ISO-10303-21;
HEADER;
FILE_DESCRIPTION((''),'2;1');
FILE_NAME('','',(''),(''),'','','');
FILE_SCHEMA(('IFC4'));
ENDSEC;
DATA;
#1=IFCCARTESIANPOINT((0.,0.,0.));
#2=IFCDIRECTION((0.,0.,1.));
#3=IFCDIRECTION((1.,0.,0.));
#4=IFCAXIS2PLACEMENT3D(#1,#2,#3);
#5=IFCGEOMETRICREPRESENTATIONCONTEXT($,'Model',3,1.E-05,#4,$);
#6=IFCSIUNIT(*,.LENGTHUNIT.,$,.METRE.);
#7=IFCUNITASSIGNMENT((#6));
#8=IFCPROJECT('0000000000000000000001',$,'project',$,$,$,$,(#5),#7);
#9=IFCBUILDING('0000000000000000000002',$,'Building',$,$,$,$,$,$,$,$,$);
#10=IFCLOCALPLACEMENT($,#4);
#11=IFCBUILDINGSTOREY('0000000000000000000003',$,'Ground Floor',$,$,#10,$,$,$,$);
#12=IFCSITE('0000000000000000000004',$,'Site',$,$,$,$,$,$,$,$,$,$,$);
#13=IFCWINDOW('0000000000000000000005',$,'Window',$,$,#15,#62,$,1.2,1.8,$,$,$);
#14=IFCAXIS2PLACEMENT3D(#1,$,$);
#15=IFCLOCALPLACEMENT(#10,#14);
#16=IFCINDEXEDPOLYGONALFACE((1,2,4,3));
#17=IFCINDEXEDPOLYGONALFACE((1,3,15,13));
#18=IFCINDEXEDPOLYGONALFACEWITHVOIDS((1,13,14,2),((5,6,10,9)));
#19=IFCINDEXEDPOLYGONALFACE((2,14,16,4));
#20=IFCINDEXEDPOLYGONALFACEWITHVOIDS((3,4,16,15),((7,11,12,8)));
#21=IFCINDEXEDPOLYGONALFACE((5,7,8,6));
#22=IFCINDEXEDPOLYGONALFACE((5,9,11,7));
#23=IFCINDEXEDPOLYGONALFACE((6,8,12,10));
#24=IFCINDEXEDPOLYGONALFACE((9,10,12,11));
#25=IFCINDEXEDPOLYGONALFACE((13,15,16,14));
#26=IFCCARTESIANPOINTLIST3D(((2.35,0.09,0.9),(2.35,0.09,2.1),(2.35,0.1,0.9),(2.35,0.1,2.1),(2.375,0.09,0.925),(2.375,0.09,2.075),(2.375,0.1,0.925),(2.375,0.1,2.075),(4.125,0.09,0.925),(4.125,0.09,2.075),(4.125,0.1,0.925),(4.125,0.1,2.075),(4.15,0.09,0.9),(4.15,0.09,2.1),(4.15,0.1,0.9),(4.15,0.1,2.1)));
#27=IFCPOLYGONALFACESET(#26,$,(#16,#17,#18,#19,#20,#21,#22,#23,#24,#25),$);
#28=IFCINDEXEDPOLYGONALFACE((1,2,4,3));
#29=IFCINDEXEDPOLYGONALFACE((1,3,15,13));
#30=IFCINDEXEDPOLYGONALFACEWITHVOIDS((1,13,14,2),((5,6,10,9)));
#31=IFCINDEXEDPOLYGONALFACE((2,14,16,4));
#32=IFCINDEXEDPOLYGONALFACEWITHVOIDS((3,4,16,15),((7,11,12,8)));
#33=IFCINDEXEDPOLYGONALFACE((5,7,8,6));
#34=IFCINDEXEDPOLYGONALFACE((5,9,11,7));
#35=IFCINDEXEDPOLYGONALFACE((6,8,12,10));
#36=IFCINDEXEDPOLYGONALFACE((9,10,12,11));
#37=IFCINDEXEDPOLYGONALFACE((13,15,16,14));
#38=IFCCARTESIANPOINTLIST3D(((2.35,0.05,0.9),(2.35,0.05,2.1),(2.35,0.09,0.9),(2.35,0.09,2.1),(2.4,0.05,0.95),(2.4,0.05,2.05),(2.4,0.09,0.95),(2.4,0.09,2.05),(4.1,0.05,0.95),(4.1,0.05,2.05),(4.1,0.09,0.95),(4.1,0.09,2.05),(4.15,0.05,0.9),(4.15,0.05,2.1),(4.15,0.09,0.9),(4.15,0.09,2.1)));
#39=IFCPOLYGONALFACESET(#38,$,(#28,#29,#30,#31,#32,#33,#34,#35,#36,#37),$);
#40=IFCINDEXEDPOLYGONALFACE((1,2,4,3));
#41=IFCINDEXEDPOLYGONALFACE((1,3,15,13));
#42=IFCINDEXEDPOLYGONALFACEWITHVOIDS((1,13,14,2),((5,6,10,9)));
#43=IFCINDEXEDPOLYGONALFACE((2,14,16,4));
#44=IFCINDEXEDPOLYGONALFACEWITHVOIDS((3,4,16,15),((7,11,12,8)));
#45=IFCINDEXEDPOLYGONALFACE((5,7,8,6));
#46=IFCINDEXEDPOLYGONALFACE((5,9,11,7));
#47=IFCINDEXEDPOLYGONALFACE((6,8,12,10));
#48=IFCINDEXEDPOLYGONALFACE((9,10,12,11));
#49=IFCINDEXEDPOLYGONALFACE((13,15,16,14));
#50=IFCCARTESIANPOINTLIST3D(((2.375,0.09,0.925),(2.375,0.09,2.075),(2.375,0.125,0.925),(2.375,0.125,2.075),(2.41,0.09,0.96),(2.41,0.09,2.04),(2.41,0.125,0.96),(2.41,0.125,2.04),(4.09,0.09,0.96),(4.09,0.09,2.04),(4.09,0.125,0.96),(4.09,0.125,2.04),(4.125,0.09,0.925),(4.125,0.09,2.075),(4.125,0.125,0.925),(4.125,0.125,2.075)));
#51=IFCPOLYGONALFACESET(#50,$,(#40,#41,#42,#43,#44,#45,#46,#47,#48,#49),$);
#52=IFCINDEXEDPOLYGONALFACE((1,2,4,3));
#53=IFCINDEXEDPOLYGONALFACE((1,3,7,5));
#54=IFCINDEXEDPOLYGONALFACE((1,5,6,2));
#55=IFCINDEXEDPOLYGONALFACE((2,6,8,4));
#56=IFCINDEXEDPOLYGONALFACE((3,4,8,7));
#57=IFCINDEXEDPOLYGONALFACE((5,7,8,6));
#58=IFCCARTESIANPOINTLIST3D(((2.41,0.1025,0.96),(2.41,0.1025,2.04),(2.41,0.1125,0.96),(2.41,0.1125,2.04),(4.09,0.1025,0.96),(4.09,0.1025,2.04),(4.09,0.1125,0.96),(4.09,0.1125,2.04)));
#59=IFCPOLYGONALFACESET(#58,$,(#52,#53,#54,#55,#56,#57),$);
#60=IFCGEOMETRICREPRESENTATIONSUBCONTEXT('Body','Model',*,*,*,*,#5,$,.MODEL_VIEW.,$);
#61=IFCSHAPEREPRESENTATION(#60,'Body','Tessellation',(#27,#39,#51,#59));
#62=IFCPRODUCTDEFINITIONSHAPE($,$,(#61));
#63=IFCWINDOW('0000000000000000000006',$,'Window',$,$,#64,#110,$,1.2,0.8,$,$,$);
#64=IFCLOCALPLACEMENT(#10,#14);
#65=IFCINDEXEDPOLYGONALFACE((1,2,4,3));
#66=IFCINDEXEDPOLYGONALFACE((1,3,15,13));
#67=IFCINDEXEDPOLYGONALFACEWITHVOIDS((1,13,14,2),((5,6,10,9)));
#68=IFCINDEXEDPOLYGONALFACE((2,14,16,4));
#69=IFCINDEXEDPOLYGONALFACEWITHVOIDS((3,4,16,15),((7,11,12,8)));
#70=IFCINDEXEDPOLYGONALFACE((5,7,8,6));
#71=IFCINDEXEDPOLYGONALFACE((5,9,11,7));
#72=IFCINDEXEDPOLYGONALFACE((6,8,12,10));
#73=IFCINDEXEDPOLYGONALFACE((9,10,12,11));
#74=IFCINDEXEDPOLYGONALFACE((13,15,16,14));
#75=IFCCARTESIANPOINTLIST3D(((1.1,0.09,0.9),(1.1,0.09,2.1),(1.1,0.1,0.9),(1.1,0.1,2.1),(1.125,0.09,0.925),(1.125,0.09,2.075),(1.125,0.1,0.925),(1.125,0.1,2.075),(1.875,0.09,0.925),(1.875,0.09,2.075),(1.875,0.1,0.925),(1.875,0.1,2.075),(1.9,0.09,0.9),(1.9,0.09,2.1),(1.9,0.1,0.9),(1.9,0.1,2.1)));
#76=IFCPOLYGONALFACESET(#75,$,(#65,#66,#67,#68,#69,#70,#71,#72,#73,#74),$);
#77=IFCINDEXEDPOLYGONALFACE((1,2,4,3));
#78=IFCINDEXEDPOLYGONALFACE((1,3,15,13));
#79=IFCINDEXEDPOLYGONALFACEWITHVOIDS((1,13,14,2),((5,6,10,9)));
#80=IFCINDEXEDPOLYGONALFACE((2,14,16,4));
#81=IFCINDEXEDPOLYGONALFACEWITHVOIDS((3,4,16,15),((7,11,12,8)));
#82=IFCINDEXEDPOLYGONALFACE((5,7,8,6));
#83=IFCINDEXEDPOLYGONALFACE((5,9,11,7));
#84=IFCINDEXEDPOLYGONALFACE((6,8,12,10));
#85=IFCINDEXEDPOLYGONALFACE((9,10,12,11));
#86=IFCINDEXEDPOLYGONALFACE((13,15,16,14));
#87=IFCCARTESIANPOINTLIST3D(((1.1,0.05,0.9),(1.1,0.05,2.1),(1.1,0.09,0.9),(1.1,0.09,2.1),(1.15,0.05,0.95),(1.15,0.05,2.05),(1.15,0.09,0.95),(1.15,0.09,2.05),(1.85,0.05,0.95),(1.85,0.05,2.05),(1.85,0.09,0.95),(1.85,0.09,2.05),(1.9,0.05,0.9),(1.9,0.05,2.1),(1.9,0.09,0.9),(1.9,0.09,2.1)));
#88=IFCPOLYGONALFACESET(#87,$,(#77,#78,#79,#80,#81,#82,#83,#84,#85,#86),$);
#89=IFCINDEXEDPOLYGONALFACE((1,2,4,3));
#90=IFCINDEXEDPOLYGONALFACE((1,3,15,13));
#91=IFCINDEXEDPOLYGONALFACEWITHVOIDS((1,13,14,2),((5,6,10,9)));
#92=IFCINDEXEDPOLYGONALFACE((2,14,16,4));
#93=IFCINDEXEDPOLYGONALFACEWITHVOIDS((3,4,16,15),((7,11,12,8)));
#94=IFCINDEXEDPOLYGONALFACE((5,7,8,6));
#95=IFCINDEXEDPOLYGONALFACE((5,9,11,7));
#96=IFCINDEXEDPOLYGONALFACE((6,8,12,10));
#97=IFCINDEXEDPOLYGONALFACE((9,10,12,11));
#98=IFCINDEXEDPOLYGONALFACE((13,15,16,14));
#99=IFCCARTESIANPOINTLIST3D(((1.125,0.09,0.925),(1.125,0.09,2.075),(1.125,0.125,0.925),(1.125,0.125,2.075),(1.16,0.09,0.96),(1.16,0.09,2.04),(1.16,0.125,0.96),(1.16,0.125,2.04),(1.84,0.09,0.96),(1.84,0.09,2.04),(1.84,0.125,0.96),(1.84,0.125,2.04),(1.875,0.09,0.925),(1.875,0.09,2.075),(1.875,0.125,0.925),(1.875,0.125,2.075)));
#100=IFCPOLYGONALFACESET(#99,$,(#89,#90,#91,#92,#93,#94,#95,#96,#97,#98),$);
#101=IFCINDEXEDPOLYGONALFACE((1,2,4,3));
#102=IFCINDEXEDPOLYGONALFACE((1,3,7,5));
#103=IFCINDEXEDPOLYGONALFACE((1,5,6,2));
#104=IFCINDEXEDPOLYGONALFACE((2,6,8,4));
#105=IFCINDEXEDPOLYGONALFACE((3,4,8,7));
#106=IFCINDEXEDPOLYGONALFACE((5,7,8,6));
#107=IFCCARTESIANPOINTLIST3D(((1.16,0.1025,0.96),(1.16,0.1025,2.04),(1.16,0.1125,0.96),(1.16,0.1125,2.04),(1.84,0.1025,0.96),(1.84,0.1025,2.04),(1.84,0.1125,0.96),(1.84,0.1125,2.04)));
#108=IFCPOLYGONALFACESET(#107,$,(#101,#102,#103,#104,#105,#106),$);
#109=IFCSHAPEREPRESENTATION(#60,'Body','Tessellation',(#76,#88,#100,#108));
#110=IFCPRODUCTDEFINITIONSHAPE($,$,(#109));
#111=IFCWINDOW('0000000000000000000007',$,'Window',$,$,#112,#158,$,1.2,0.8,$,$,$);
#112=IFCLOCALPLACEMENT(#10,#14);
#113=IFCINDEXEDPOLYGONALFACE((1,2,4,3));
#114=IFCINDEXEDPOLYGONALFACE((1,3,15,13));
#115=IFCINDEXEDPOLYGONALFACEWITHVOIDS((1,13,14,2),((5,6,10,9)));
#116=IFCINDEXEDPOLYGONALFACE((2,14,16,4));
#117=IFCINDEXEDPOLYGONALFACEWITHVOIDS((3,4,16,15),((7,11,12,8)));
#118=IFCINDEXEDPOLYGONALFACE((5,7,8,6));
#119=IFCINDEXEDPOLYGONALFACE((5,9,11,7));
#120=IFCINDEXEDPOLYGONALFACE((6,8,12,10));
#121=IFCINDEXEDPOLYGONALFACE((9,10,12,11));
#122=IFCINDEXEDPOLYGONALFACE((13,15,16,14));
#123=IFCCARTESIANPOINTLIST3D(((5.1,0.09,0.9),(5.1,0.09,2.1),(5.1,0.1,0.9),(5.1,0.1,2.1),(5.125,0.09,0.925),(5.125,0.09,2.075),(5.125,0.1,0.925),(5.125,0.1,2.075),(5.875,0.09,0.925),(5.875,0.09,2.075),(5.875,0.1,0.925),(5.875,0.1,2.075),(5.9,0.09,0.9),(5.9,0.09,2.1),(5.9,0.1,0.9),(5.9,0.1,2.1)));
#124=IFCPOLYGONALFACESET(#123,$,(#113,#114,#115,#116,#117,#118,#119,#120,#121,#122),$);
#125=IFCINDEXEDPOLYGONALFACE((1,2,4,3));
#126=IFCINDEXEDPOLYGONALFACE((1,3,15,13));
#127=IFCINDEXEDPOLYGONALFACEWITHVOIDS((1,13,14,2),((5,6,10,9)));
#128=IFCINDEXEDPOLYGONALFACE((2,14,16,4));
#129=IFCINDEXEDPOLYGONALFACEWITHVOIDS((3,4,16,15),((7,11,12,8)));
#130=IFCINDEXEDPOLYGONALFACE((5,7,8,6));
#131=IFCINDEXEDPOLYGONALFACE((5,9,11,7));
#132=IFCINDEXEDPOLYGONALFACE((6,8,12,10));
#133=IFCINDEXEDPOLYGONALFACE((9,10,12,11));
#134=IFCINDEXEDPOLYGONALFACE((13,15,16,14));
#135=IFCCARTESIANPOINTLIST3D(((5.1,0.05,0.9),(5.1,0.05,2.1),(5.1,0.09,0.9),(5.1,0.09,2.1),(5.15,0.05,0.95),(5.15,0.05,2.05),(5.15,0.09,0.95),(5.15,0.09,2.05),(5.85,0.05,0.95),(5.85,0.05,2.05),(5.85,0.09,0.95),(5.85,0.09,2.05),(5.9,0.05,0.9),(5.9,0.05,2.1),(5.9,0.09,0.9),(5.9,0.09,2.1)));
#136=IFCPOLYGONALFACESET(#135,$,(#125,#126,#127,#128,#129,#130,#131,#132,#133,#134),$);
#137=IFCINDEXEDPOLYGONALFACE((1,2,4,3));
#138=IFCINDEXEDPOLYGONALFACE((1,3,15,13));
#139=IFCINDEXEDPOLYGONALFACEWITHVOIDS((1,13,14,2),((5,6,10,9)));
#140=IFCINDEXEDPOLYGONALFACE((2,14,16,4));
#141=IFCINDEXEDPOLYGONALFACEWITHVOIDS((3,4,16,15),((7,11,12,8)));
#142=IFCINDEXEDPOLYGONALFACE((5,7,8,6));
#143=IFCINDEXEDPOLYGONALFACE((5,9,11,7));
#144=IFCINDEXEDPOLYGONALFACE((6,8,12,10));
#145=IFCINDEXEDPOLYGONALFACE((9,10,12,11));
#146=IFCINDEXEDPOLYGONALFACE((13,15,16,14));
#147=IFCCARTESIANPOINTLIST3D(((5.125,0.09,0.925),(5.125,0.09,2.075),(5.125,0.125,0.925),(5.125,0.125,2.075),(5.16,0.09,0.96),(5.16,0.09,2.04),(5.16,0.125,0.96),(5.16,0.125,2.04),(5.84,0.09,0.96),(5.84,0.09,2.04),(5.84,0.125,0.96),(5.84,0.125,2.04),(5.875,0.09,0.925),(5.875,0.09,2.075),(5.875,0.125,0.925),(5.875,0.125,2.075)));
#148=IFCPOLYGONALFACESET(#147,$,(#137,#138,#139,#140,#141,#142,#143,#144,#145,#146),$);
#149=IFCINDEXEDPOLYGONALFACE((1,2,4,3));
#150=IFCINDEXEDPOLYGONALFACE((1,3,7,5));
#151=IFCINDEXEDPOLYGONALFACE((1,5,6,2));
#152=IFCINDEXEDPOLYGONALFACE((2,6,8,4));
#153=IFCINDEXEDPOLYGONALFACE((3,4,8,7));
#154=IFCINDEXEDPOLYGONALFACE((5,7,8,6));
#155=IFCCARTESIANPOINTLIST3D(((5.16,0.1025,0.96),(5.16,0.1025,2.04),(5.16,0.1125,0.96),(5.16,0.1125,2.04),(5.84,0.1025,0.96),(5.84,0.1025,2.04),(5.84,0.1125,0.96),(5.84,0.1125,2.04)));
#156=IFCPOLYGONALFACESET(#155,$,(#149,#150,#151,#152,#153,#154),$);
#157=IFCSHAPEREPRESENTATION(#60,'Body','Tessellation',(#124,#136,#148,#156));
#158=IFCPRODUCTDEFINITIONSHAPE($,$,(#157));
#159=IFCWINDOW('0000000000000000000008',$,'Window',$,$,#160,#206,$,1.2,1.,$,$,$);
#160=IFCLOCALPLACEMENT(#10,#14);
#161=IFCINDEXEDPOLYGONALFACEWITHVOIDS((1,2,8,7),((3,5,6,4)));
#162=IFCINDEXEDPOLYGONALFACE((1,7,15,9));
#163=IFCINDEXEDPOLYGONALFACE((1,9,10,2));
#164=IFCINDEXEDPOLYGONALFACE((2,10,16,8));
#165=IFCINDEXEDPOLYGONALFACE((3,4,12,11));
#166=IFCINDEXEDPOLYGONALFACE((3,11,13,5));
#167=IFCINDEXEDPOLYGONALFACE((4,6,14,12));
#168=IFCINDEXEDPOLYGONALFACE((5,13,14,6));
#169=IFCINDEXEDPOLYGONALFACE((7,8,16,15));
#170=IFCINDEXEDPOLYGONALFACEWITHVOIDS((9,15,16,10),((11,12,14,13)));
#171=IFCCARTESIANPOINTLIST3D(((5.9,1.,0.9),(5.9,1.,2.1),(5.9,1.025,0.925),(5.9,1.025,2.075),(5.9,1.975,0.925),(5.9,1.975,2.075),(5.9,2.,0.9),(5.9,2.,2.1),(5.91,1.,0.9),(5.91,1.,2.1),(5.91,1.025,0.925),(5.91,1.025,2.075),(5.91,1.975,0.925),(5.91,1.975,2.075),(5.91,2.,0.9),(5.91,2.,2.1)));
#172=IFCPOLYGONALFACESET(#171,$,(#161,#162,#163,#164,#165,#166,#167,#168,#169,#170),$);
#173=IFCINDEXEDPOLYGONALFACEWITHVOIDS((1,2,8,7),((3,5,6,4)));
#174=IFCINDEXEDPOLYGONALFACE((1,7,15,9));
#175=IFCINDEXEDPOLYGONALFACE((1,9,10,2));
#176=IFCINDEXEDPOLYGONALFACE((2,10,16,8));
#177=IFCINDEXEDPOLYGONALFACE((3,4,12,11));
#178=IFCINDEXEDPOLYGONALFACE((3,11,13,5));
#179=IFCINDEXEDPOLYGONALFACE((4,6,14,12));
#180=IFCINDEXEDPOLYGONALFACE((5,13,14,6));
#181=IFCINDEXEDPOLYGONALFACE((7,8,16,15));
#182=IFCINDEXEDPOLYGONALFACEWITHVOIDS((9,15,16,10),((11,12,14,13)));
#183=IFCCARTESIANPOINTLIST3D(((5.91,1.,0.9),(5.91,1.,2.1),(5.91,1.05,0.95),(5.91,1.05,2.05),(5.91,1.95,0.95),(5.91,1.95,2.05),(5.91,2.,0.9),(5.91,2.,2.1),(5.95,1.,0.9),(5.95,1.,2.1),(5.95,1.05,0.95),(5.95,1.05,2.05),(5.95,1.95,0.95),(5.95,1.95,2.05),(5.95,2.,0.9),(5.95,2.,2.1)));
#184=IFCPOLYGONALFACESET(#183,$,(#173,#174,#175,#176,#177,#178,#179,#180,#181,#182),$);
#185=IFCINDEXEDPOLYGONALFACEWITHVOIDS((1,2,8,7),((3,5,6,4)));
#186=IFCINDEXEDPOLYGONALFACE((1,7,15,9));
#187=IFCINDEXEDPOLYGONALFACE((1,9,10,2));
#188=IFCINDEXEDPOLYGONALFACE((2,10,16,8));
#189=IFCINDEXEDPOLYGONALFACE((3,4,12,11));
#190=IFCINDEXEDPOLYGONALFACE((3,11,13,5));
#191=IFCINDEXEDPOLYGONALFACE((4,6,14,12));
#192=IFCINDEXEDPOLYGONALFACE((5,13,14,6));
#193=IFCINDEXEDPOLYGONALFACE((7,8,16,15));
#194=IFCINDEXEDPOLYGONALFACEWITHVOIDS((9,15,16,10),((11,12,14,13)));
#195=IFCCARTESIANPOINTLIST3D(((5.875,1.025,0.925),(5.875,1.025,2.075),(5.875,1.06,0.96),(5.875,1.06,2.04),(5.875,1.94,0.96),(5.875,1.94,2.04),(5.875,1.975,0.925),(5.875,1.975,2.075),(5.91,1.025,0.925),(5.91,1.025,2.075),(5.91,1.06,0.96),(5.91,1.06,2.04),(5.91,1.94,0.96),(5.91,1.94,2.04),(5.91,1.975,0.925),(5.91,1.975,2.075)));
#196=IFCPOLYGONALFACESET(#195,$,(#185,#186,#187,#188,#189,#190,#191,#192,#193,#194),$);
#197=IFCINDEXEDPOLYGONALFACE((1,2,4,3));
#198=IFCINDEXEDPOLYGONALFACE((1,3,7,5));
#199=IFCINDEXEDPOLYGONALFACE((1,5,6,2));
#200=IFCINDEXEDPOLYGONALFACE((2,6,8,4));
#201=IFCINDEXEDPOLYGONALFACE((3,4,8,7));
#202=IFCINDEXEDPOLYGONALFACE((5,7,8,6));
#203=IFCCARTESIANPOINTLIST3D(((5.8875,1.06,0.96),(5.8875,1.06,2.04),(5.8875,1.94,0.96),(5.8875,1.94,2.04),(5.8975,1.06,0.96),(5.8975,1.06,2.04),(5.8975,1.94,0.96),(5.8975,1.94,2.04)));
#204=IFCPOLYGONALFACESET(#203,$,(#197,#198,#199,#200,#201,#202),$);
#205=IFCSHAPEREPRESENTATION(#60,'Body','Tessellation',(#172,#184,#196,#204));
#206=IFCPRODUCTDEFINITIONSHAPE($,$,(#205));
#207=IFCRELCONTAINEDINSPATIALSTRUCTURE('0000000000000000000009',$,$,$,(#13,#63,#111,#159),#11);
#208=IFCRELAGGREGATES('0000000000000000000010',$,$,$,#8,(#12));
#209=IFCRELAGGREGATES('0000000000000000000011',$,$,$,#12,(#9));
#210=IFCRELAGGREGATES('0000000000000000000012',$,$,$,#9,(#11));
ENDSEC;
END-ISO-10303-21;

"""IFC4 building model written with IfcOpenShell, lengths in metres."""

from ifc_helpers import new_model, si_unit, frame, origin_with_axes, place, context, subcontext, project, spatial, line, indexed_curve, outline, extrude, element, save


model = new_model("IFC4")

# Units and contexts
model_context = context("Model", 3, precision=1e-05, world=origin_with_axes())
body_context = subcontext(model_context, "Body", "Model", "MODEL_VIEW")
ifc_project = project(units=[si_unit("LENGTHUNIT", "METRE")], contexts=[model_context])

# Site, building, storey
site = spatial("IfcSite", under=ifc_project, Name="Site")
building = spatial("IfcBuilding", under=site, Name="Building")
storey_placement = place(None, origin_with_axes())
storey = spatial("IfcBuildingStorey", under=building, at=storey_placement, Name="Ground Floor")

# Windows
window_1_placement = place(storey_placement, frame((2.35, 0.0, 0.9), z_axis=(0.0, 0.0, 1.0), x_axis=(1.0, 0.0, 0.0)))
element("IfcWindow", 1, at=window_1_placement, inside=storey, Name="Window", OverallHeight=1.2, OverallWidth=1.8, context=body_context, shape_type="SweptSolid", body=[
    extrude(outline(indexed_curve([(0.0, 0.0), (1.8, 0.0), (1.8, 1.2), (0.0, 1.2)], segments=[line(1, 2, 3, 4, 1)]), holes=[indexed_curve([(0.025, 0.025), (1.775, 0.025), (1.775, 1.175), (0.025, 1.175)], segments=[line(1, 2, 3, 4, 1)])]), frame((0.0, 0.09, 0.0), z_axis=(0.0, -1.0, 0.0), x_axis=(1.0, 0.0, 0.0)), (0.0, 0.0, -1.0), 0.01),
    extrude(outline(indexed_curve([(0.0, 0.0), (1.8, 0.0), (1.8, 1.2), (0.0, 1.2)], segments=[line(1, 2, 3, 4, 1)]), holes=[indexed_curve([(0.05, 0.05), (1.75, 0.05), (1.75, 1.15), (0.05, 1.15)], segments=[line(1, 2, 3, 4, 1)])]), frame((0.0, 0.05, 0.0), z_axis=(0.0, -1.0, 0.0), x_axis=(1.0, 0.0, 0.0)), (0.0, 0.0, -1.0), 0.04),
    extrude(outline(indexed_curve([(0.0, 0.0), (1.75, 0.0), (1.75, 1.15), (0.0, 1.15)], segments=[line(1, 2, 3, 4, 1)]), holes=[indexed_curve([(0.035, 0.035), (1.715, 0.035), (1.715, 1.115), (0.035, 1.115)], segments=[line(1, 2, 3, 4, 1)])]), frame((0.025, 0.09, 0.025), z_axis=(0.0, -1.0, 0.0), x_axis=(1.0, 0.0, 0.0)), (0.0, 0.0, -1.0), 0.035),
    extrude(outline(indexed_curve([(0.035, 0.035), (1.715, 0.035), (1.715, 1.115), (0.035, 1.115)], segments=[line(1, 2, 3, 4, 1)])), frame((0.025, 0.1025, 0.025), z_axis=(0.0, -1.0, 0.0), x_axis=(1.0, 0.0, 0.0)), (0.0, 0.0, -1.0), 0.01),
])
for number, where, z_axis, x_axis, name in (
    (2, (1.1, 0.0, 0.9), (0.0, 0.0, 1.0), (1.0, 0.0, 0.0), "Window"),
    (3, (5.1, 0.0, 0.9), (0.0, 0.0, 1.0), (1.0, 0.0, 0.0), "Window"),
):
    element("IfcWindow", number, at=place(storey_placement, frame(where, z_axis=z_axis, x_axis=x_axis)), inside=storey, Name=name, OverallHeight=1.2, OverallWidth=0.8, context=body_context, shape_type="SweptSolid", body=[
        extrude(outline(indexed_curve([(0.0, 0.0), (0.8, 0.0), (0.8, 1.2), (0.0, 1.2)], segments=[line(1, 2, 3, 4, 1)]), holes=[indexed_curve([(0.025, 0.025), (0.775, 0.025), (0.775, 1.175), (0.025, 1.175)], segments=[line(1, 2, 3, 4, 1)])]), frame((0.0, 0.09, 0.0), z_axis=(0.0, -1.0, 0.0), x_axis=(1.0, 0.0, 0.0)), (0.0, 0.0, -1.0), 0.01),
        extrude(outline(indexed_curve([(0.0, 0.0), (0.8, 0.0), (0.8, 1.2), (0.0, 1.2)], segments=[line(1, 2, 3, 4, 1)]), holes=[indexed_curve([(0.05, 0.05), (0.75, 0.05), (0.75, 1.15), (0.05, 1.15)], segments=[line(1, 2, 3, 4, 1)])]), frame((0.0, 0.05, 0.0), z_axis=(0.0, -1.0, 0.0), x_axis=(1.0, 0.0, 0.0)), (0.0, 0.0, -1.0), 0.04),
        extrude(outline(indexed_curve([(0.0, 0.0), (0.75, 0.0), (0.75, 1.15), (0.0, 1.15)], segments=[line(1, 2, 3, 4, 1)]), holes=[indexed_curve([(0.035, 0.035), (0.715, 0.035), (0.715, 1.115), (0.035, 1.115)], segments=[line(1, 2, 3, 4, 1)])]), frame((0.025, 0.09, 0.025), z_axis=(0.0, -1.0, 0.0), x_axis=(1.0, 0.0, 0.0)), (0.0, 0.0, -1.0), 0.035),
        extrude(outline(indexed_curve([(0.035, 0.035), (0.715, 0.035), (0.715, 1.115), (0.035, 1.115)], segments=[line(1, 2, 3, 4, 1)])), frame((0.025, 0.1025, 0.025), z_axis=(0.0, -1.0, 0.0), x_axis=(1.0, 0.0, 0.0)), (0.0, 0.0, -1.0), 0.01),
    ])
window_2_placement = place(storey_placement, frame((6.0, 1.0, 0.9), z_axis=(0.0, 0.0, 1.0), x_axis=(0.0, 1.0, 0.0)))
element("IfcWindow", 4, at=window_2_placement, inside=storey, Name="Window", OverallHeight=1.2, OverallWidth=1.0, context=body_context, shape_type="SweptSolid", body=[
    extrude(outline(indexed_curve([(0.0, 0.0), (1.0, 0.0), (1.0, 1.2), (0.0, 1.2)], segments=[line(1, 2, 3, 4, 1)]), holes=[indexed_curve([(0.025, 0.025), (0.975, 0.025), (0.975, 1.175), (0.025, 1.175)], segments=[line(1, 2, 3, 4, 1)])]), frame((0.0, 0.09, 0.0), z_axis=(0.0, -1.0, 0.0), x_axis=(1.0, 0.0, 0.0)), (0.0, 0.0, -1.0), 0.01),
    extrude(outline(indexed_curve([(0.0, 0.0), (1.0, 0.0), (1.0, 1.2), (0.0, 1.2)], segments=[line(1, 2, 3, 4, 1)]), holes=[indexed_curve([(0.05, 0.05), (0.95, 0.05), (0.95, 1.15), (0.05, 1.15)], segments=[line(1, 2, 3, 4, 1)])]), frame((0.0, 0.05, 0.0), z_axis=(0.0, -1.0, 0.0), x_axis=(1.0, 0.0, 0.0)), (0.0, 0.0, -1.0), 0.04),
    extrude(outline(indexed_curve([(0.0, 0.0), (0.95, 0.0), (0.95, 1.15), (0.0, 1.15)], segments=[line(1, 2, 3, 4, 1)]), holes=[indexed_curve([(0.035, 0.035), (0.915, 0.035), (0.915, 1.115), (0.035, 1.115)], segments=[line(1, 2, 3, 4, 1)])]), frame((0.025, 0.09, 0.025), z_axis=(0.0, -1.0, 0.0), x_axis=(1.0, 0.0, 0.0)), (0.0, 0.0, -1.0), 0.035),
    extrude(outline(indexed_curve([(0.035, 0.035), (0.915, 0.035), (0.915, 1.115), (0.035, 1.115)], segments=[line(1, 2, 3, 4, 1)])), frame((0.025, 0.1025, 0.025), z_axis=(0.0, -1.0, 0.0), x_axis=(1.0, 0.0, 0.0)), (0.0, 0.0, -1.0), 0.01),
])

save(model, "model.ifc")
